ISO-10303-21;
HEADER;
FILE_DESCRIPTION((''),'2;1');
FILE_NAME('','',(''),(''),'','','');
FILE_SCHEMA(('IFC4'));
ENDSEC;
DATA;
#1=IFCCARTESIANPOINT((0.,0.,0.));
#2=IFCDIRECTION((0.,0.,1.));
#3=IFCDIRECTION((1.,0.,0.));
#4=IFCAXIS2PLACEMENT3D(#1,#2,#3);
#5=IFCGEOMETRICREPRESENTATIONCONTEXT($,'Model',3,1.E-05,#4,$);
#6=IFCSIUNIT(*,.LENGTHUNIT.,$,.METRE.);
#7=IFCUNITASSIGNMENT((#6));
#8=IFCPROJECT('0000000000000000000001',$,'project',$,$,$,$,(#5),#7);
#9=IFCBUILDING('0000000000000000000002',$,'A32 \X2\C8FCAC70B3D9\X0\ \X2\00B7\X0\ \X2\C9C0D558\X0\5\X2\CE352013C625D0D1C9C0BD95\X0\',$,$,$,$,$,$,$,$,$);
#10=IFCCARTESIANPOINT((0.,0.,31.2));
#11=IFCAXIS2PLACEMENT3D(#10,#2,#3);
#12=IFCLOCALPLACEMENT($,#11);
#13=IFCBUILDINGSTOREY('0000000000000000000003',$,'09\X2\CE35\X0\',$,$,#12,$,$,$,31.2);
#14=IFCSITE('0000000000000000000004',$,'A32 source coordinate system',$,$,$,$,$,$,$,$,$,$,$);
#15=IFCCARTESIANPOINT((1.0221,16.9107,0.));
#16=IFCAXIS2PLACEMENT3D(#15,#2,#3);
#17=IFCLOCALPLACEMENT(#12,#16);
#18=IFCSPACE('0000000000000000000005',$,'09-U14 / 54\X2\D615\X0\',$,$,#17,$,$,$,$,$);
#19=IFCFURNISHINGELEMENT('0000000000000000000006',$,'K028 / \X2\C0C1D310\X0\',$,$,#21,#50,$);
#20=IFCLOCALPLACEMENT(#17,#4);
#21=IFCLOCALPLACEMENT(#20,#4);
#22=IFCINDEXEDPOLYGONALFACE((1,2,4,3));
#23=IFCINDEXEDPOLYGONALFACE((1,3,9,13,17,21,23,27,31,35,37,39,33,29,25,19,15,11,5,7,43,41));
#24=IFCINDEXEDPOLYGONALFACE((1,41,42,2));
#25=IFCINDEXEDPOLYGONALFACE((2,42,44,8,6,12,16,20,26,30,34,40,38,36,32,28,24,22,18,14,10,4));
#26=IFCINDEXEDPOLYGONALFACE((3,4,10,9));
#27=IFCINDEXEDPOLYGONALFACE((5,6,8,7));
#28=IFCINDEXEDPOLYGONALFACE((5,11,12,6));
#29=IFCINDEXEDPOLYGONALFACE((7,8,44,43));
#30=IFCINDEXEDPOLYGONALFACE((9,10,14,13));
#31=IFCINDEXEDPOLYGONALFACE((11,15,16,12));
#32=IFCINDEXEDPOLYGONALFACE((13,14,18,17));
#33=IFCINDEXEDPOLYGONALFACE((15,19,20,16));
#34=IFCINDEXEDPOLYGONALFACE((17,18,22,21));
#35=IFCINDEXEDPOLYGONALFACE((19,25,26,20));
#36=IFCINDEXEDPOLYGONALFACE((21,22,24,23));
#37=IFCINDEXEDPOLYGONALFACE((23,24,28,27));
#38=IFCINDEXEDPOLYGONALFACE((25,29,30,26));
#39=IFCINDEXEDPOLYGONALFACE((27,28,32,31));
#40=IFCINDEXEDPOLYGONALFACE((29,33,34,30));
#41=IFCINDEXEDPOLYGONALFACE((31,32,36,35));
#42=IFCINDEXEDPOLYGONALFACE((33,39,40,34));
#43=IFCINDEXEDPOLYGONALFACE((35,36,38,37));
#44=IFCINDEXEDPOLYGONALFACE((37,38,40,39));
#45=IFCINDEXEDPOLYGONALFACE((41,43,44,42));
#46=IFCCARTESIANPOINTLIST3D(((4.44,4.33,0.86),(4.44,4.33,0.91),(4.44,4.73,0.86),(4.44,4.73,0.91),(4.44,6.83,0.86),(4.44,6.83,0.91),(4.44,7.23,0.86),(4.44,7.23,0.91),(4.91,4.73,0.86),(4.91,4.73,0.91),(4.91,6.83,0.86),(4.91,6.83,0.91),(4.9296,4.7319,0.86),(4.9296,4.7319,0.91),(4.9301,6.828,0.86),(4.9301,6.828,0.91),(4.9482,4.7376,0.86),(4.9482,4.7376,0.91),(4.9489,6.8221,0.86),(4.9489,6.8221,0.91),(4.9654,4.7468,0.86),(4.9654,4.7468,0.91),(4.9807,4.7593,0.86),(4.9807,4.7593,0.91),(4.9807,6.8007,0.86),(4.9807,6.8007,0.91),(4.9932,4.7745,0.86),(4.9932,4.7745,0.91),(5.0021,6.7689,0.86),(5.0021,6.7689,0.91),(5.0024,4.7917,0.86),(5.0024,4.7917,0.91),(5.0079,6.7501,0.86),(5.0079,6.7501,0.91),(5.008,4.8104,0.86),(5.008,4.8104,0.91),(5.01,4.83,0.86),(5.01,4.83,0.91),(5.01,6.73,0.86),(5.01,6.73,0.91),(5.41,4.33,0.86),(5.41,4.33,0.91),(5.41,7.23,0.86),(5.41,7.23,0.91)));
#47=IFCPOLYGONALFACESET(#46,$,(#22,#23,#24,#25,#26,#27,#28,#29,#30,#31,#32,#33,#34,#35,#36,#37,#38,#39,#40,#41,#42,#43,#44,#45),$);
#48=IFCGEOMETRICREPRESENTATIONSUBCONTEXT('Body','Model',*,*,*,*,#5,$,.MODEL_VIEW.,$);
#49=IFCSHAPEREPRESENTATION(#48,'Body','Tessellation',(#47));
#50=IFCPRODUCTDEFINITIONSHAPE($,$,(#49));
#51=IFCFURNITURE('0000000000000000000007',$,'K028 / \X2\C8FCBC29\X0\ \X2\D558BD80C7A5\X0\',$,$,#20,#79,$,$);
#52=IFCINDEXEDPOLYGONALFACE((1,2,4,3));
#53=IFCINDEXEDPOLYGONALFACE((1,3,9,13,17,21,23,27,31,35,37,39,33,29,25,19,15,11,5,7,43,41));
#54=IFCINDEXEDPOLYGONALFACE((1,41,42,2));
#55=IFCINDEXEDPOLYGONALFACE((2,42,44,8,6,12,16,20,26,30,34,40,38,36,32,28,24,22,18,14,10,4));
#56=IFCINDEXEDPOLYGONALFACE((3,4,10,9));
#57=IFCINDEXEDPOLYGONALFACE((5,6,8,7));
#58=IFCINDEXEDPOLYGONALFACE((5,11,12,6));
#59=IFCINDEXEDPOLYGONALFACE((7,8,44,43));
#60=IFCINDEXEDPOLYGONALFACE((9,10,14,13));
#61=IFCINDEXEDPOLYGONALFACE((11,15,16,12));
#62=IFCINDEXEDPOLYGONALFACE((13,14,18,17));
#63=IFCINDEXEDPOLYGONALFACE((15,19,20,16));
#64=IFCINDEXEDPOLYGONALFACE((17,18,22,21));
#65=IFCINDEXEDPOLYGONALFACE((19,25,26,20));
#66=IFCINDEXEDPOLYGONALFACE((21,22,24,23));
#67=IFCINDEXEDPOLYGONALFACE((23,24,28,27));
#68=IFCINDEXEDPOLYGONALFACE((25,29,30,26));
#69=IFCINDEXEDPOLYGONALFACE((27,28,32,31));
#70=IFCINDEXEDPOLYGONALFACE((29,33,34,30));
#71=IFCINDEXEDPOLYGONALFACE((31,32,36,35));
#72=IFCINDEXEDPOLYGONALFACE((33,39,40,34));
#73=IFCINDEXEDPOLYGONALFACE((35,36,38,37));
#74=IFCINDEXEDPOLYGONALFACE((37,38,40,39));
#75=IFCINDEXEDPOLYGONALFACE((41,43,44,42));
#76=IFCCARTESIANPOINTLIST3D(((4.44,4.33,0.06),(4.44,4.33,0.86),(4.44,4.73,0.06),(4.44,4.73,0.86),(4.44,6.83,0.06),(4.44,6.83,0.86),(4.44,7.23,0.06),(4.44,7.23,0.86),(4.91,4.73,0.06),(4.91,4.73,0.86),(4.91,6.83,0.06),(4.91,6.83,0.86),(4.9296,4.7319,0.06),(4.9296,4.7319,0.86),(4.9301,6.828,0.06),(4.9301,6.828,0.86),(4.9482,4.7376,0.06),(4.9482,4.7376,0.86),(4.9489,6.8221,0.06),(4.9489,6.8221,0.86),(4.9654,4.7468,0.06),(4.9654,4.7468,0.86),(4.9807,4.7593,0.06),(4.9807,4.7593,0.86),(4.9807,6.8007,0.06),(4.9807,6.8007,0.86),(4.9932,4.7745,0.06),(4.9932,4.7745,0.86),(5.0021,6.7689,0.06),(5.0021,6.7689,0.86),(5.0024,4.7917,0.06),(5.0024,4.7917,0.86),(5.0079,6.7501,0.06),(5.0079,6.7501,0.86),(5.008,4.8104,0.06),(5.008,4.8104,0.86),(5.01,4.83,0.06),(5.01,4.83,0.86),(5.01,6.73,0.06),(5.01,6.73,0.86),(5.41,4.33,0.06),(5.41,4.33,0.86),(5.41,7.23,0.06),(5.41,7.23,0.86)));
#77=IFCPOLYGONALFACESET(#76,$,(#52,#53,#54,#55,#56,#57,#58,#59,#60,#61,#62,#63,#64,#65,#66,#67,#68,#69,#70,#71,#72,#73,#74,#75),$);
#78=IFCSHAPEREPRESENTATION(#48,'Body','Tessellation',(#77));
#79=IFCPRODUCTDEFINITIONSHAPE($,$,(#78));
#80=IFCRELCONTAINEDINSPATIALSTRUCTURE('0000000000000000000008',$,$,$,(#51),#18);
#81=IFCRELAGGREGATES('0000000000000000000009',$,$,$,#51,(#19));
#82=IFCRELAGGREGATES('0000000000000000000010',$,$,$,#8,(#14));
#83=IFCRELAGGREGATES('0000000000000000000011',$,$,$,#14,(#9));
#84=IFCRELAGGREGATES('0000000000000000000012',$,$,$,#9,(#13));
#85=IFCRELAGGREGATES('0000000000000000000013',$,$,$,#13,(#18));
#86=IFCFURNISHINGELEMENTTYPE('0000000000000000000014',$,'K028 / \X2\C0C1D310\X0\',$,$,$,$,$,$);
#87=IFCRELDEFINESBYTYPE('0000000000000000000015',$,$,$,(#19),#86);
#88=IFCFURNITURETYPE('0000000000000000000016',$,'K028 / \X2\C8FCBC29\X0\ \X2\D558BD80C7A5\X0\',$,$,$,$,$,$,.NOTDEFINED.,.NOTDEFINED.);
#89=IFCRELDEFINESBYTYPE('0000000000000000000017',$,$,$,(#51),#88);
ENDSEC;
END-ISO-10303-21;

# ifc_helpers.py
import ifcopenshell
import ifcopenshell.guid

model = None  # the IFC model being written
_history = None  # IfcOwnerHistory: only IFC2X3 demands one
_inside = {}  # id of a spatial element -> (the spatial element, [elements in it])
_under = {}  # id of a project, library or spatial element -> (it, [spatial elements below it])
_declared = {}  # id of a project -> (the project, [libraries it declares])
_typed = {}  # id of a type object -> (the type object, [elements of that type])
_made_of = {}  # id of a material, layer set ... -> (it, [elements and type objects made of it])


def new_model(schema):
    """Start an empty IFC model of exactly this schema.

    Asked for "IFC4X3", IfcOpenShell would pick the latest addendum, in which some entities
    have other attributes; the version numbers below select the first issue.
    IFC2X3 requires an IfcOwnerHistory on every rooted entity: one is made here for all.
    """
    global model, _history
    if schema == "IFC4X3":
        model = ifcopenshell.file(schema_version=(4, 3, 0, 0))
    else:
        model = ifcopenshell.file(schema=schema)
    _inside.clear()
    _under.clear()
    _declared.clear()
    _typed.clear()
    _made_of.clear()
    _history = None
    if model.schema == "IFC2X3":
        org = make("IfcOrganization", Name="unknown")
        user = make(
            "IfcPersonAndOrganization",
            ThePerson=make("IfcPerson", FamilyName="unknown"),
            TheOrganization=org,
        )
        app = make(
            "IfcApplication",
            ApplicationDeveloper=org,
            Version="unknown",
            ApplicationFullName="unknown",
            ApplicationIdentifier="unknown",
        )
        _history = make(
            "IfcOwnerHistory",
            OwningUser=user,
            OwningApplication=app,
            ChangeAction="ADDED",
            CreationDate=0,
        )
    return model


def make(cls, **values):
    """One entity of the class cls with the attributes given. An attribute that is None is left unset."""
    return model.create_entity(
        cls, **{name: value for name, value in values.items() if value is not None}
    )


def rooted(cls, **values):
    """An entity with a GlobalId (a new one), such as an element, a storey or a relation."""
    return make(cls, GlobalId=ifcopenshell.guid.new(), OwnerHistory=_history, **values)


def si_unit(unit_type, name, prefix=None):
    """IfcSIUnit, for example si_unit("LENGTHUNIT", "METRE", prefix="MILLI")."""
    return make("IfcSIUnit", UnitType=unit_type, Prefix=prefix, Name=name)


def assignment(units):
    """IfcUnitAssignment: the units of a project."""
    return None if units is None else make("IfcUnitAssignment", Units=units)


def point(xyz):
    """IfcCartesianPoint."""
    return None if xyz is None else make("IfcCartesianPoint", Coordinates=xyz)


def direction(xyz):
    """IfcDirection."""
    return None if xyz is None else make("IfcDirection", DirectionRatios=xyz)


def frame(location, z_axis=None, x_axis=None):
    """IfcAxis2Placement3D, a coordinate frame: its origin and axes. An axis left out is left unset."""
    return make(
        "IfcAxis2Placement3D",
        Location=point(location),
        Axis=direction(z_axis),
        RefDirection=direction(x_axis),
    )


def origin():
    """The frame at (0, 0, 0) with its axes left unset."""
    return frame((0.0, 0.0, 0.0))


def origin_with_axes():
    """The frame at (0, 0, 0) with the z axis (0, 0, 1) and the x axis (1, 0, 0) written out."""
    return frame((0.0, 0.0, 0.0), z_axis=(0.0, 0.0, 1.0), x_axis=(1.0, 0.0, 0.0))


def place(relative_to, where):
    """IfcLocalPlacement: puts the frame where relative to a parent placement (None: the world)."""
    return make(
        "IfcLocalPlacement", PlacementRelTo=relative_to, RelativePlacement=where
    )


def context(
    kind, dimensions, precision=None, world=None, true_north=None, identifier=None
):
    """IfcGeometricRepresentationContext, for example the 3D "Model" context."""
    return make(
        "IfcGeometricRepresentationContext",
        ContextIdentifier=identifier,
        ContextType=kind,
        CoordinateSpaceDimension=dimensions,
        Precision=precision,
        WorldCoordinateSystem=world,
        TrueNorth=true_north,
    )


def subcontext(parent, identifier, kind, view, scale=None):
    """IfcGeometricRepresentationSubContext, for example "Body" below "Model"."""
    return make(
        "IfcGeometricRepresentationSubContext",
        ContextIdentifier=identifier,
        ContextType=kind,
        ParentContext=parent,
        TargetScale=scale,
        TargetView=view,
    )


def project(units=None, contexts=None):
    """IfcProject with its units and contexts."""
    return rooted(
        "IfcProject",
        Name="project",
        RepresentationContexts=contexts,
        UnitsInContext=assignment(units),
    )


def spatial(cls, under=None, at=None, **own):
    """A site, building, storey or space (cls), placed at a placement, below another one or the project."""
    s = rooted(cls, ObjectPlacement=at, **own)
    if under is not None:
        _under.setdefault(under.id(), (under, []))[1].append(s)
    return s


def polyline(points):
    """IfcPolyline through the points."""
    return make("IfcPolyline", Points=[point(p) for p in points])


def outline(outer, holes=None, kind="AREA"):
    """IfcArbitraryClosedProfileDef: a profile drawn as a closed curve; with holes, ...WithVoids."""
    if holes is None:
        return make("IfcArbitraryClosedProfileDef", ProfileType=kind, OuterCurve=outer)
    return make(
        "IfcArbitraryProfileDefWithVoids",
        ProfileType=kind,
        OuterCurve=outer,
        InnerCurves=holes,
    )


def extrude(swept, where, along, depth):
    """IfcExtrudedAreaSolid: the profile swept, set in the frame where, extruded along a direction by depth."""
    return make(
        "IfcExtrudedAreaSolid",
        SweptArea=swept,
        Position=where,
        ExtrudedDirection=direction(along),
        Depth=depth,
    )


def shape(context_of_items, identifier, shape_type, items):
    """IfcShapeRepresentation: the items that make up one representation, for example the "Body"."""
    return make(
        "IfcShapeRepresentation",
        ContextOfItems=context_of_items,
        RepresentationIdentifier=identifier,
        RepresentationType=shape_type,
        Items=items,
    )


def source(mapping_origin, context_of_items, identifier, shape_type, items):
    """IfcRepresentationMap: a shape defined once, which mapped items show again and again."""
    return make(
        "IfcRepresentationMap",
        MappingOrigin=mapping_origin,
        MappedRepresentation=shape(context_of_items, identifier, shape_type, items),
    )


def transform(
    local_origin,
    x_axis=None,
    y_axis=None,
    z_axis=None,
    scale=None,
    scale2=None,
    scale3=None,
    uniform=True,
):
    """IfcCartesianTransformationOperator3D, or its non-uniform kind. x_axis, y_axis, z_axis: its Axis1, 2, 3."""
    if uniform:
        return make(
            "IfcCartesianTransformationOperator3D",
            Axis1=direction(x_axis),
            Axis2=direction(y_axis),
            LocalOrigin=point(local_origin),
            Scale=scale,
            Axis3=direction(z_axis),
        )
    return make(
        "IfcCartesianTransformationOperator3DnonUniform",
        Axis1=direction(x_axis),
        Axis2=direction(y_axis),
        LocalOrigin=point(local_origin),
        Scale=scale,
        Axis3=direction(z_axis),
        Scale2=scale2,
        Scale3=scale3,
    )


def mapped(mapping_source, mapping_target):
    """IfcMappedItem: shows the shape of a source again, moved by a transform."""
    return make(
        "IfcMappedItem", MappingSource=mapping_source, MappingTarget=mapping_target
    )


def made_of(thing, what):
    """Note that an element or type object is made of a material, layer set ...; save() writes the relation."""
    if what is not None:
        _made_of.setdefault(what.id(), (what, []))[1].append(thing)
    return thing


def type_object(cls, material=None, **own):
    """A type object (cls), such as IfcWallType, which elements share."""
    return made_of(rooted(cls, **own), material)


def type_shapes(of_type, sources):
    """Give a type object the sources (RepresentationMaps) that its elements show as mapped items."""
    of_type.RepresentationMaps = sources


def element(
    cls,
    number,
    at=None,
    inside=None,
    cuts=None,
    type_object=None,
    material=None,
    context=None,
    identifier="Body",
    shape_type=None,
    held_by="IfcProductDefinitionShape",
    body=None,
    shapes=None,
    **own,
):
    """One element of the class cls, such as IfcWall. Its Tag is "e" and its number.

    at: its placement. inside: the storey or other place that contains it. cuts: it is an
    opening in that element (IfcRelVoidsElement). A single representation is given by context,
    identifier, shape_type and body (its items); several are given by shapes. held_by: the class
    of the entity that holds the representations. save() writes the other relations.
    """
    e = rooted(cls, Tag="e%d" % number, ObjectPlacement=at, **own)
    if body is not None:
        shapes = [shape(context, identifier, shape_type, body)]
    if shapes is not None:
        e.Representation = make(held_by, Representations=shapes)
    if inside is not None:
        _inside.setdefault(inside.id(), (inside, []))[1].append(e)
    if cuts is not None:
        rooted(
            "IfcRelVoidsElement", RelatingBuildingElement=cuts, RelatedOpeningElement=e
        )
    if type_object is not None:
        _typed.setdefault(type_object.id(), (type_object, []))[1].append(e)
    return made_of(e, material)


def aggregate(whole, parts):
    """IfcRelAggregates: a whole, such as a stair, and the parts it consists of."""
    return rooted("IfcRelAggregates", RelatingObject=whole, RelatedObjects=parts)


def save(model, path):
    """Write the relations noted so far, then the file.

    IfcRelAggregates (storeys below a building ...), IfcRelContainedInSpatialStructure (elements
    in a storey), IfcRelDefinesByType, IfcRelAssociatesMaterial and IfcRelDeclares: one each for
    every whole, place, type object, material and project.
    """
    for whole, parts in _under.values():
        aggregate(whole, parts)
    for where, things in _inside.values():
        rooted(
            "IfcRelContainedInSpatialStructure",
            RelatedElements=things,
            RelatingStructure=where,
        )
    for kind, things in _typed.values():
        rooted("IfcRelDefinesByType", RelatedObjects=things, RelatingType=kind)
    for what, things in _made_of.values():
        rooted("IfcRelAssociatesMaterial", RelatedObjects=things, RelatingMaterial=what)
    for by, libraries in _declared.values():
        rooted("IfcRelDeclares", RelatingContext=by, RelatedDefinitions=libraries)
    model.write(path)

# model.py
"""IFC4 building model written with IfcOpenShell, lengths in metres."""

from ifc_helpers import new_model, si_unit, frame, origin, origin_with_axes, place, context, subcontext, project, spatial, polyline, outline, extrude, source, transform, mapped, type_object, type_shapes, element, aggregate, save


model = new_model("IFC4")

# Units and contexts
model_context = context("Model", 3, precision=1e-05, world=origin_with_axes())
body_context = subcontext(model_context, "Body", "Model", "MODEL_VIEW")
ifc_project = project(units=[si_unit("LENGTHUNIT", "METRE")], contexts=[model_context])

# Site, building, storey, space
site = spatial("IfcSite", under=ifc_project, Name="A32 source coordinate system")
building = spatial("IfcBuilding", under=site, Name="A32 주거동 · 지하5층–옥탑지붕")
storey_placement = place(None, frame((0.0, 0.0, 31.2), z_axis=(0.0, 0.0, 1.0), x_axis=(1.0, 0.0, 0.0)))
storey = spatial("IfcBuildingStorey", under=building, at=storey_placement, Name="09층", Elevation=31.2)
space_placement = place(storey_placement, frame((1.0221, 16.9107, 0.0), z_axis=(0.0, 0.0, 1.0), x_axis=(1.0, 0.0, 0.0)))
space = spatial("IfcSpace", under=storey, at=space_placement, Name="09-U14 / 54형")

# Furnishing element
furnishing_element_type_1 = type_object("IfcFurnishingElementType", Name="K028 / 상판")
shared_shape_1 = source(origin(), body_context, "Body", "SweptSolid", [
    extrude(outline(polyline([(5.41, 4.33), (4.44, 4.33), (4.44, 4.73), (4.91, 4.73), (4.9296, 4.7319), (4.9482, 4.7376), (4.9654, 4.7468), (4.9807, 4.7593), (4.9932, 4.7745), (5.0024, 4.7917), (5.008, 4.8104), (5.01, 4.83), (5.01, 6.73), (5.0079, 6.7501), (5.0021, 6.7689), (4.9807, 6.8007), (4.9489, 6.8221), (4.9301, 6.828), (4.91, 6.83), (4.44, 6.83), (4.44, 7.23), (5.41, 7.23), (5.41, 4.33)])), frame((0.0, 0.0, 0.86)), (0.0, 0.0, 1.0), 0.05),
])
type_shapes(furnishing_element_type_1, [shared_shape_1])
furniture_1_placement = place(space_placement, origin_with_axes())
furnishing_1_placement = place(furniture_1_placement, origin_with_axes())
furnishing_1 = element("IfcFurnishingElement", 1, at=furnishing_1_placement, type_object=furnishing_element_type_1, Name="K028 / 상판", context=body_context, shape_type="MappedRepresentation", body=[
    mapped(shared_shape_1, transform((0.0, 0.0, 0.0), scale=1.0)),
])

# Furniture
furniture_type_1 = type_object("IfcFurnitureType", Name="K028 / 주방 하부장", AssemblyPlace="NOTDEFINED", PredefinedType="NOTDEFINED")
shared_shape_2 = source(origin(), body_context, "Body", "SweptSolid", [
    extrude(outline(polyline([(5.41, 7.23), (5.41, 4.33), (4.44, 4.33), (4.44, 4.73), (4.91, 4.73), (4.9296, 4.7319), (4.9482, 4.7376), (4.9654, 4.7468), (4.9807, 4.7593), (4.9932, 4.7745), (5.0024, 4.7917), (5.008, 4.8104), (5.01, 4.83), (5.01, 6.73), (5.0079, 6.7501), (5.0021, 6.7689), (4.9807, 6.8007), (4.9489, 6.8221), (4.9301, 6.828), (4.91, 6.83), (4.44, 6.83), (4.44, 7.23), (5.41, 7.23)])), frame((0.0, 0.0, 0.06)), (0.0, 0.0, 1.0), 0.8),
])
type_shapes(furniture_type_1, [shared_shape_2])
furniture_1 = element("IfcFurniture", 2, at=furniture_1_placement, inside=space, type_object=furniture_type_1, Name="K028 / 주방 하부장", context=body_context, shape_type="MappedRepresentation", body=[
    mapped(shared_shape_2, transform((0.0, 0.0, 0.0), scale=1.0)),
])
aggregate(furniture_1, [furnishing_1])

save(model, "model.ifc")
